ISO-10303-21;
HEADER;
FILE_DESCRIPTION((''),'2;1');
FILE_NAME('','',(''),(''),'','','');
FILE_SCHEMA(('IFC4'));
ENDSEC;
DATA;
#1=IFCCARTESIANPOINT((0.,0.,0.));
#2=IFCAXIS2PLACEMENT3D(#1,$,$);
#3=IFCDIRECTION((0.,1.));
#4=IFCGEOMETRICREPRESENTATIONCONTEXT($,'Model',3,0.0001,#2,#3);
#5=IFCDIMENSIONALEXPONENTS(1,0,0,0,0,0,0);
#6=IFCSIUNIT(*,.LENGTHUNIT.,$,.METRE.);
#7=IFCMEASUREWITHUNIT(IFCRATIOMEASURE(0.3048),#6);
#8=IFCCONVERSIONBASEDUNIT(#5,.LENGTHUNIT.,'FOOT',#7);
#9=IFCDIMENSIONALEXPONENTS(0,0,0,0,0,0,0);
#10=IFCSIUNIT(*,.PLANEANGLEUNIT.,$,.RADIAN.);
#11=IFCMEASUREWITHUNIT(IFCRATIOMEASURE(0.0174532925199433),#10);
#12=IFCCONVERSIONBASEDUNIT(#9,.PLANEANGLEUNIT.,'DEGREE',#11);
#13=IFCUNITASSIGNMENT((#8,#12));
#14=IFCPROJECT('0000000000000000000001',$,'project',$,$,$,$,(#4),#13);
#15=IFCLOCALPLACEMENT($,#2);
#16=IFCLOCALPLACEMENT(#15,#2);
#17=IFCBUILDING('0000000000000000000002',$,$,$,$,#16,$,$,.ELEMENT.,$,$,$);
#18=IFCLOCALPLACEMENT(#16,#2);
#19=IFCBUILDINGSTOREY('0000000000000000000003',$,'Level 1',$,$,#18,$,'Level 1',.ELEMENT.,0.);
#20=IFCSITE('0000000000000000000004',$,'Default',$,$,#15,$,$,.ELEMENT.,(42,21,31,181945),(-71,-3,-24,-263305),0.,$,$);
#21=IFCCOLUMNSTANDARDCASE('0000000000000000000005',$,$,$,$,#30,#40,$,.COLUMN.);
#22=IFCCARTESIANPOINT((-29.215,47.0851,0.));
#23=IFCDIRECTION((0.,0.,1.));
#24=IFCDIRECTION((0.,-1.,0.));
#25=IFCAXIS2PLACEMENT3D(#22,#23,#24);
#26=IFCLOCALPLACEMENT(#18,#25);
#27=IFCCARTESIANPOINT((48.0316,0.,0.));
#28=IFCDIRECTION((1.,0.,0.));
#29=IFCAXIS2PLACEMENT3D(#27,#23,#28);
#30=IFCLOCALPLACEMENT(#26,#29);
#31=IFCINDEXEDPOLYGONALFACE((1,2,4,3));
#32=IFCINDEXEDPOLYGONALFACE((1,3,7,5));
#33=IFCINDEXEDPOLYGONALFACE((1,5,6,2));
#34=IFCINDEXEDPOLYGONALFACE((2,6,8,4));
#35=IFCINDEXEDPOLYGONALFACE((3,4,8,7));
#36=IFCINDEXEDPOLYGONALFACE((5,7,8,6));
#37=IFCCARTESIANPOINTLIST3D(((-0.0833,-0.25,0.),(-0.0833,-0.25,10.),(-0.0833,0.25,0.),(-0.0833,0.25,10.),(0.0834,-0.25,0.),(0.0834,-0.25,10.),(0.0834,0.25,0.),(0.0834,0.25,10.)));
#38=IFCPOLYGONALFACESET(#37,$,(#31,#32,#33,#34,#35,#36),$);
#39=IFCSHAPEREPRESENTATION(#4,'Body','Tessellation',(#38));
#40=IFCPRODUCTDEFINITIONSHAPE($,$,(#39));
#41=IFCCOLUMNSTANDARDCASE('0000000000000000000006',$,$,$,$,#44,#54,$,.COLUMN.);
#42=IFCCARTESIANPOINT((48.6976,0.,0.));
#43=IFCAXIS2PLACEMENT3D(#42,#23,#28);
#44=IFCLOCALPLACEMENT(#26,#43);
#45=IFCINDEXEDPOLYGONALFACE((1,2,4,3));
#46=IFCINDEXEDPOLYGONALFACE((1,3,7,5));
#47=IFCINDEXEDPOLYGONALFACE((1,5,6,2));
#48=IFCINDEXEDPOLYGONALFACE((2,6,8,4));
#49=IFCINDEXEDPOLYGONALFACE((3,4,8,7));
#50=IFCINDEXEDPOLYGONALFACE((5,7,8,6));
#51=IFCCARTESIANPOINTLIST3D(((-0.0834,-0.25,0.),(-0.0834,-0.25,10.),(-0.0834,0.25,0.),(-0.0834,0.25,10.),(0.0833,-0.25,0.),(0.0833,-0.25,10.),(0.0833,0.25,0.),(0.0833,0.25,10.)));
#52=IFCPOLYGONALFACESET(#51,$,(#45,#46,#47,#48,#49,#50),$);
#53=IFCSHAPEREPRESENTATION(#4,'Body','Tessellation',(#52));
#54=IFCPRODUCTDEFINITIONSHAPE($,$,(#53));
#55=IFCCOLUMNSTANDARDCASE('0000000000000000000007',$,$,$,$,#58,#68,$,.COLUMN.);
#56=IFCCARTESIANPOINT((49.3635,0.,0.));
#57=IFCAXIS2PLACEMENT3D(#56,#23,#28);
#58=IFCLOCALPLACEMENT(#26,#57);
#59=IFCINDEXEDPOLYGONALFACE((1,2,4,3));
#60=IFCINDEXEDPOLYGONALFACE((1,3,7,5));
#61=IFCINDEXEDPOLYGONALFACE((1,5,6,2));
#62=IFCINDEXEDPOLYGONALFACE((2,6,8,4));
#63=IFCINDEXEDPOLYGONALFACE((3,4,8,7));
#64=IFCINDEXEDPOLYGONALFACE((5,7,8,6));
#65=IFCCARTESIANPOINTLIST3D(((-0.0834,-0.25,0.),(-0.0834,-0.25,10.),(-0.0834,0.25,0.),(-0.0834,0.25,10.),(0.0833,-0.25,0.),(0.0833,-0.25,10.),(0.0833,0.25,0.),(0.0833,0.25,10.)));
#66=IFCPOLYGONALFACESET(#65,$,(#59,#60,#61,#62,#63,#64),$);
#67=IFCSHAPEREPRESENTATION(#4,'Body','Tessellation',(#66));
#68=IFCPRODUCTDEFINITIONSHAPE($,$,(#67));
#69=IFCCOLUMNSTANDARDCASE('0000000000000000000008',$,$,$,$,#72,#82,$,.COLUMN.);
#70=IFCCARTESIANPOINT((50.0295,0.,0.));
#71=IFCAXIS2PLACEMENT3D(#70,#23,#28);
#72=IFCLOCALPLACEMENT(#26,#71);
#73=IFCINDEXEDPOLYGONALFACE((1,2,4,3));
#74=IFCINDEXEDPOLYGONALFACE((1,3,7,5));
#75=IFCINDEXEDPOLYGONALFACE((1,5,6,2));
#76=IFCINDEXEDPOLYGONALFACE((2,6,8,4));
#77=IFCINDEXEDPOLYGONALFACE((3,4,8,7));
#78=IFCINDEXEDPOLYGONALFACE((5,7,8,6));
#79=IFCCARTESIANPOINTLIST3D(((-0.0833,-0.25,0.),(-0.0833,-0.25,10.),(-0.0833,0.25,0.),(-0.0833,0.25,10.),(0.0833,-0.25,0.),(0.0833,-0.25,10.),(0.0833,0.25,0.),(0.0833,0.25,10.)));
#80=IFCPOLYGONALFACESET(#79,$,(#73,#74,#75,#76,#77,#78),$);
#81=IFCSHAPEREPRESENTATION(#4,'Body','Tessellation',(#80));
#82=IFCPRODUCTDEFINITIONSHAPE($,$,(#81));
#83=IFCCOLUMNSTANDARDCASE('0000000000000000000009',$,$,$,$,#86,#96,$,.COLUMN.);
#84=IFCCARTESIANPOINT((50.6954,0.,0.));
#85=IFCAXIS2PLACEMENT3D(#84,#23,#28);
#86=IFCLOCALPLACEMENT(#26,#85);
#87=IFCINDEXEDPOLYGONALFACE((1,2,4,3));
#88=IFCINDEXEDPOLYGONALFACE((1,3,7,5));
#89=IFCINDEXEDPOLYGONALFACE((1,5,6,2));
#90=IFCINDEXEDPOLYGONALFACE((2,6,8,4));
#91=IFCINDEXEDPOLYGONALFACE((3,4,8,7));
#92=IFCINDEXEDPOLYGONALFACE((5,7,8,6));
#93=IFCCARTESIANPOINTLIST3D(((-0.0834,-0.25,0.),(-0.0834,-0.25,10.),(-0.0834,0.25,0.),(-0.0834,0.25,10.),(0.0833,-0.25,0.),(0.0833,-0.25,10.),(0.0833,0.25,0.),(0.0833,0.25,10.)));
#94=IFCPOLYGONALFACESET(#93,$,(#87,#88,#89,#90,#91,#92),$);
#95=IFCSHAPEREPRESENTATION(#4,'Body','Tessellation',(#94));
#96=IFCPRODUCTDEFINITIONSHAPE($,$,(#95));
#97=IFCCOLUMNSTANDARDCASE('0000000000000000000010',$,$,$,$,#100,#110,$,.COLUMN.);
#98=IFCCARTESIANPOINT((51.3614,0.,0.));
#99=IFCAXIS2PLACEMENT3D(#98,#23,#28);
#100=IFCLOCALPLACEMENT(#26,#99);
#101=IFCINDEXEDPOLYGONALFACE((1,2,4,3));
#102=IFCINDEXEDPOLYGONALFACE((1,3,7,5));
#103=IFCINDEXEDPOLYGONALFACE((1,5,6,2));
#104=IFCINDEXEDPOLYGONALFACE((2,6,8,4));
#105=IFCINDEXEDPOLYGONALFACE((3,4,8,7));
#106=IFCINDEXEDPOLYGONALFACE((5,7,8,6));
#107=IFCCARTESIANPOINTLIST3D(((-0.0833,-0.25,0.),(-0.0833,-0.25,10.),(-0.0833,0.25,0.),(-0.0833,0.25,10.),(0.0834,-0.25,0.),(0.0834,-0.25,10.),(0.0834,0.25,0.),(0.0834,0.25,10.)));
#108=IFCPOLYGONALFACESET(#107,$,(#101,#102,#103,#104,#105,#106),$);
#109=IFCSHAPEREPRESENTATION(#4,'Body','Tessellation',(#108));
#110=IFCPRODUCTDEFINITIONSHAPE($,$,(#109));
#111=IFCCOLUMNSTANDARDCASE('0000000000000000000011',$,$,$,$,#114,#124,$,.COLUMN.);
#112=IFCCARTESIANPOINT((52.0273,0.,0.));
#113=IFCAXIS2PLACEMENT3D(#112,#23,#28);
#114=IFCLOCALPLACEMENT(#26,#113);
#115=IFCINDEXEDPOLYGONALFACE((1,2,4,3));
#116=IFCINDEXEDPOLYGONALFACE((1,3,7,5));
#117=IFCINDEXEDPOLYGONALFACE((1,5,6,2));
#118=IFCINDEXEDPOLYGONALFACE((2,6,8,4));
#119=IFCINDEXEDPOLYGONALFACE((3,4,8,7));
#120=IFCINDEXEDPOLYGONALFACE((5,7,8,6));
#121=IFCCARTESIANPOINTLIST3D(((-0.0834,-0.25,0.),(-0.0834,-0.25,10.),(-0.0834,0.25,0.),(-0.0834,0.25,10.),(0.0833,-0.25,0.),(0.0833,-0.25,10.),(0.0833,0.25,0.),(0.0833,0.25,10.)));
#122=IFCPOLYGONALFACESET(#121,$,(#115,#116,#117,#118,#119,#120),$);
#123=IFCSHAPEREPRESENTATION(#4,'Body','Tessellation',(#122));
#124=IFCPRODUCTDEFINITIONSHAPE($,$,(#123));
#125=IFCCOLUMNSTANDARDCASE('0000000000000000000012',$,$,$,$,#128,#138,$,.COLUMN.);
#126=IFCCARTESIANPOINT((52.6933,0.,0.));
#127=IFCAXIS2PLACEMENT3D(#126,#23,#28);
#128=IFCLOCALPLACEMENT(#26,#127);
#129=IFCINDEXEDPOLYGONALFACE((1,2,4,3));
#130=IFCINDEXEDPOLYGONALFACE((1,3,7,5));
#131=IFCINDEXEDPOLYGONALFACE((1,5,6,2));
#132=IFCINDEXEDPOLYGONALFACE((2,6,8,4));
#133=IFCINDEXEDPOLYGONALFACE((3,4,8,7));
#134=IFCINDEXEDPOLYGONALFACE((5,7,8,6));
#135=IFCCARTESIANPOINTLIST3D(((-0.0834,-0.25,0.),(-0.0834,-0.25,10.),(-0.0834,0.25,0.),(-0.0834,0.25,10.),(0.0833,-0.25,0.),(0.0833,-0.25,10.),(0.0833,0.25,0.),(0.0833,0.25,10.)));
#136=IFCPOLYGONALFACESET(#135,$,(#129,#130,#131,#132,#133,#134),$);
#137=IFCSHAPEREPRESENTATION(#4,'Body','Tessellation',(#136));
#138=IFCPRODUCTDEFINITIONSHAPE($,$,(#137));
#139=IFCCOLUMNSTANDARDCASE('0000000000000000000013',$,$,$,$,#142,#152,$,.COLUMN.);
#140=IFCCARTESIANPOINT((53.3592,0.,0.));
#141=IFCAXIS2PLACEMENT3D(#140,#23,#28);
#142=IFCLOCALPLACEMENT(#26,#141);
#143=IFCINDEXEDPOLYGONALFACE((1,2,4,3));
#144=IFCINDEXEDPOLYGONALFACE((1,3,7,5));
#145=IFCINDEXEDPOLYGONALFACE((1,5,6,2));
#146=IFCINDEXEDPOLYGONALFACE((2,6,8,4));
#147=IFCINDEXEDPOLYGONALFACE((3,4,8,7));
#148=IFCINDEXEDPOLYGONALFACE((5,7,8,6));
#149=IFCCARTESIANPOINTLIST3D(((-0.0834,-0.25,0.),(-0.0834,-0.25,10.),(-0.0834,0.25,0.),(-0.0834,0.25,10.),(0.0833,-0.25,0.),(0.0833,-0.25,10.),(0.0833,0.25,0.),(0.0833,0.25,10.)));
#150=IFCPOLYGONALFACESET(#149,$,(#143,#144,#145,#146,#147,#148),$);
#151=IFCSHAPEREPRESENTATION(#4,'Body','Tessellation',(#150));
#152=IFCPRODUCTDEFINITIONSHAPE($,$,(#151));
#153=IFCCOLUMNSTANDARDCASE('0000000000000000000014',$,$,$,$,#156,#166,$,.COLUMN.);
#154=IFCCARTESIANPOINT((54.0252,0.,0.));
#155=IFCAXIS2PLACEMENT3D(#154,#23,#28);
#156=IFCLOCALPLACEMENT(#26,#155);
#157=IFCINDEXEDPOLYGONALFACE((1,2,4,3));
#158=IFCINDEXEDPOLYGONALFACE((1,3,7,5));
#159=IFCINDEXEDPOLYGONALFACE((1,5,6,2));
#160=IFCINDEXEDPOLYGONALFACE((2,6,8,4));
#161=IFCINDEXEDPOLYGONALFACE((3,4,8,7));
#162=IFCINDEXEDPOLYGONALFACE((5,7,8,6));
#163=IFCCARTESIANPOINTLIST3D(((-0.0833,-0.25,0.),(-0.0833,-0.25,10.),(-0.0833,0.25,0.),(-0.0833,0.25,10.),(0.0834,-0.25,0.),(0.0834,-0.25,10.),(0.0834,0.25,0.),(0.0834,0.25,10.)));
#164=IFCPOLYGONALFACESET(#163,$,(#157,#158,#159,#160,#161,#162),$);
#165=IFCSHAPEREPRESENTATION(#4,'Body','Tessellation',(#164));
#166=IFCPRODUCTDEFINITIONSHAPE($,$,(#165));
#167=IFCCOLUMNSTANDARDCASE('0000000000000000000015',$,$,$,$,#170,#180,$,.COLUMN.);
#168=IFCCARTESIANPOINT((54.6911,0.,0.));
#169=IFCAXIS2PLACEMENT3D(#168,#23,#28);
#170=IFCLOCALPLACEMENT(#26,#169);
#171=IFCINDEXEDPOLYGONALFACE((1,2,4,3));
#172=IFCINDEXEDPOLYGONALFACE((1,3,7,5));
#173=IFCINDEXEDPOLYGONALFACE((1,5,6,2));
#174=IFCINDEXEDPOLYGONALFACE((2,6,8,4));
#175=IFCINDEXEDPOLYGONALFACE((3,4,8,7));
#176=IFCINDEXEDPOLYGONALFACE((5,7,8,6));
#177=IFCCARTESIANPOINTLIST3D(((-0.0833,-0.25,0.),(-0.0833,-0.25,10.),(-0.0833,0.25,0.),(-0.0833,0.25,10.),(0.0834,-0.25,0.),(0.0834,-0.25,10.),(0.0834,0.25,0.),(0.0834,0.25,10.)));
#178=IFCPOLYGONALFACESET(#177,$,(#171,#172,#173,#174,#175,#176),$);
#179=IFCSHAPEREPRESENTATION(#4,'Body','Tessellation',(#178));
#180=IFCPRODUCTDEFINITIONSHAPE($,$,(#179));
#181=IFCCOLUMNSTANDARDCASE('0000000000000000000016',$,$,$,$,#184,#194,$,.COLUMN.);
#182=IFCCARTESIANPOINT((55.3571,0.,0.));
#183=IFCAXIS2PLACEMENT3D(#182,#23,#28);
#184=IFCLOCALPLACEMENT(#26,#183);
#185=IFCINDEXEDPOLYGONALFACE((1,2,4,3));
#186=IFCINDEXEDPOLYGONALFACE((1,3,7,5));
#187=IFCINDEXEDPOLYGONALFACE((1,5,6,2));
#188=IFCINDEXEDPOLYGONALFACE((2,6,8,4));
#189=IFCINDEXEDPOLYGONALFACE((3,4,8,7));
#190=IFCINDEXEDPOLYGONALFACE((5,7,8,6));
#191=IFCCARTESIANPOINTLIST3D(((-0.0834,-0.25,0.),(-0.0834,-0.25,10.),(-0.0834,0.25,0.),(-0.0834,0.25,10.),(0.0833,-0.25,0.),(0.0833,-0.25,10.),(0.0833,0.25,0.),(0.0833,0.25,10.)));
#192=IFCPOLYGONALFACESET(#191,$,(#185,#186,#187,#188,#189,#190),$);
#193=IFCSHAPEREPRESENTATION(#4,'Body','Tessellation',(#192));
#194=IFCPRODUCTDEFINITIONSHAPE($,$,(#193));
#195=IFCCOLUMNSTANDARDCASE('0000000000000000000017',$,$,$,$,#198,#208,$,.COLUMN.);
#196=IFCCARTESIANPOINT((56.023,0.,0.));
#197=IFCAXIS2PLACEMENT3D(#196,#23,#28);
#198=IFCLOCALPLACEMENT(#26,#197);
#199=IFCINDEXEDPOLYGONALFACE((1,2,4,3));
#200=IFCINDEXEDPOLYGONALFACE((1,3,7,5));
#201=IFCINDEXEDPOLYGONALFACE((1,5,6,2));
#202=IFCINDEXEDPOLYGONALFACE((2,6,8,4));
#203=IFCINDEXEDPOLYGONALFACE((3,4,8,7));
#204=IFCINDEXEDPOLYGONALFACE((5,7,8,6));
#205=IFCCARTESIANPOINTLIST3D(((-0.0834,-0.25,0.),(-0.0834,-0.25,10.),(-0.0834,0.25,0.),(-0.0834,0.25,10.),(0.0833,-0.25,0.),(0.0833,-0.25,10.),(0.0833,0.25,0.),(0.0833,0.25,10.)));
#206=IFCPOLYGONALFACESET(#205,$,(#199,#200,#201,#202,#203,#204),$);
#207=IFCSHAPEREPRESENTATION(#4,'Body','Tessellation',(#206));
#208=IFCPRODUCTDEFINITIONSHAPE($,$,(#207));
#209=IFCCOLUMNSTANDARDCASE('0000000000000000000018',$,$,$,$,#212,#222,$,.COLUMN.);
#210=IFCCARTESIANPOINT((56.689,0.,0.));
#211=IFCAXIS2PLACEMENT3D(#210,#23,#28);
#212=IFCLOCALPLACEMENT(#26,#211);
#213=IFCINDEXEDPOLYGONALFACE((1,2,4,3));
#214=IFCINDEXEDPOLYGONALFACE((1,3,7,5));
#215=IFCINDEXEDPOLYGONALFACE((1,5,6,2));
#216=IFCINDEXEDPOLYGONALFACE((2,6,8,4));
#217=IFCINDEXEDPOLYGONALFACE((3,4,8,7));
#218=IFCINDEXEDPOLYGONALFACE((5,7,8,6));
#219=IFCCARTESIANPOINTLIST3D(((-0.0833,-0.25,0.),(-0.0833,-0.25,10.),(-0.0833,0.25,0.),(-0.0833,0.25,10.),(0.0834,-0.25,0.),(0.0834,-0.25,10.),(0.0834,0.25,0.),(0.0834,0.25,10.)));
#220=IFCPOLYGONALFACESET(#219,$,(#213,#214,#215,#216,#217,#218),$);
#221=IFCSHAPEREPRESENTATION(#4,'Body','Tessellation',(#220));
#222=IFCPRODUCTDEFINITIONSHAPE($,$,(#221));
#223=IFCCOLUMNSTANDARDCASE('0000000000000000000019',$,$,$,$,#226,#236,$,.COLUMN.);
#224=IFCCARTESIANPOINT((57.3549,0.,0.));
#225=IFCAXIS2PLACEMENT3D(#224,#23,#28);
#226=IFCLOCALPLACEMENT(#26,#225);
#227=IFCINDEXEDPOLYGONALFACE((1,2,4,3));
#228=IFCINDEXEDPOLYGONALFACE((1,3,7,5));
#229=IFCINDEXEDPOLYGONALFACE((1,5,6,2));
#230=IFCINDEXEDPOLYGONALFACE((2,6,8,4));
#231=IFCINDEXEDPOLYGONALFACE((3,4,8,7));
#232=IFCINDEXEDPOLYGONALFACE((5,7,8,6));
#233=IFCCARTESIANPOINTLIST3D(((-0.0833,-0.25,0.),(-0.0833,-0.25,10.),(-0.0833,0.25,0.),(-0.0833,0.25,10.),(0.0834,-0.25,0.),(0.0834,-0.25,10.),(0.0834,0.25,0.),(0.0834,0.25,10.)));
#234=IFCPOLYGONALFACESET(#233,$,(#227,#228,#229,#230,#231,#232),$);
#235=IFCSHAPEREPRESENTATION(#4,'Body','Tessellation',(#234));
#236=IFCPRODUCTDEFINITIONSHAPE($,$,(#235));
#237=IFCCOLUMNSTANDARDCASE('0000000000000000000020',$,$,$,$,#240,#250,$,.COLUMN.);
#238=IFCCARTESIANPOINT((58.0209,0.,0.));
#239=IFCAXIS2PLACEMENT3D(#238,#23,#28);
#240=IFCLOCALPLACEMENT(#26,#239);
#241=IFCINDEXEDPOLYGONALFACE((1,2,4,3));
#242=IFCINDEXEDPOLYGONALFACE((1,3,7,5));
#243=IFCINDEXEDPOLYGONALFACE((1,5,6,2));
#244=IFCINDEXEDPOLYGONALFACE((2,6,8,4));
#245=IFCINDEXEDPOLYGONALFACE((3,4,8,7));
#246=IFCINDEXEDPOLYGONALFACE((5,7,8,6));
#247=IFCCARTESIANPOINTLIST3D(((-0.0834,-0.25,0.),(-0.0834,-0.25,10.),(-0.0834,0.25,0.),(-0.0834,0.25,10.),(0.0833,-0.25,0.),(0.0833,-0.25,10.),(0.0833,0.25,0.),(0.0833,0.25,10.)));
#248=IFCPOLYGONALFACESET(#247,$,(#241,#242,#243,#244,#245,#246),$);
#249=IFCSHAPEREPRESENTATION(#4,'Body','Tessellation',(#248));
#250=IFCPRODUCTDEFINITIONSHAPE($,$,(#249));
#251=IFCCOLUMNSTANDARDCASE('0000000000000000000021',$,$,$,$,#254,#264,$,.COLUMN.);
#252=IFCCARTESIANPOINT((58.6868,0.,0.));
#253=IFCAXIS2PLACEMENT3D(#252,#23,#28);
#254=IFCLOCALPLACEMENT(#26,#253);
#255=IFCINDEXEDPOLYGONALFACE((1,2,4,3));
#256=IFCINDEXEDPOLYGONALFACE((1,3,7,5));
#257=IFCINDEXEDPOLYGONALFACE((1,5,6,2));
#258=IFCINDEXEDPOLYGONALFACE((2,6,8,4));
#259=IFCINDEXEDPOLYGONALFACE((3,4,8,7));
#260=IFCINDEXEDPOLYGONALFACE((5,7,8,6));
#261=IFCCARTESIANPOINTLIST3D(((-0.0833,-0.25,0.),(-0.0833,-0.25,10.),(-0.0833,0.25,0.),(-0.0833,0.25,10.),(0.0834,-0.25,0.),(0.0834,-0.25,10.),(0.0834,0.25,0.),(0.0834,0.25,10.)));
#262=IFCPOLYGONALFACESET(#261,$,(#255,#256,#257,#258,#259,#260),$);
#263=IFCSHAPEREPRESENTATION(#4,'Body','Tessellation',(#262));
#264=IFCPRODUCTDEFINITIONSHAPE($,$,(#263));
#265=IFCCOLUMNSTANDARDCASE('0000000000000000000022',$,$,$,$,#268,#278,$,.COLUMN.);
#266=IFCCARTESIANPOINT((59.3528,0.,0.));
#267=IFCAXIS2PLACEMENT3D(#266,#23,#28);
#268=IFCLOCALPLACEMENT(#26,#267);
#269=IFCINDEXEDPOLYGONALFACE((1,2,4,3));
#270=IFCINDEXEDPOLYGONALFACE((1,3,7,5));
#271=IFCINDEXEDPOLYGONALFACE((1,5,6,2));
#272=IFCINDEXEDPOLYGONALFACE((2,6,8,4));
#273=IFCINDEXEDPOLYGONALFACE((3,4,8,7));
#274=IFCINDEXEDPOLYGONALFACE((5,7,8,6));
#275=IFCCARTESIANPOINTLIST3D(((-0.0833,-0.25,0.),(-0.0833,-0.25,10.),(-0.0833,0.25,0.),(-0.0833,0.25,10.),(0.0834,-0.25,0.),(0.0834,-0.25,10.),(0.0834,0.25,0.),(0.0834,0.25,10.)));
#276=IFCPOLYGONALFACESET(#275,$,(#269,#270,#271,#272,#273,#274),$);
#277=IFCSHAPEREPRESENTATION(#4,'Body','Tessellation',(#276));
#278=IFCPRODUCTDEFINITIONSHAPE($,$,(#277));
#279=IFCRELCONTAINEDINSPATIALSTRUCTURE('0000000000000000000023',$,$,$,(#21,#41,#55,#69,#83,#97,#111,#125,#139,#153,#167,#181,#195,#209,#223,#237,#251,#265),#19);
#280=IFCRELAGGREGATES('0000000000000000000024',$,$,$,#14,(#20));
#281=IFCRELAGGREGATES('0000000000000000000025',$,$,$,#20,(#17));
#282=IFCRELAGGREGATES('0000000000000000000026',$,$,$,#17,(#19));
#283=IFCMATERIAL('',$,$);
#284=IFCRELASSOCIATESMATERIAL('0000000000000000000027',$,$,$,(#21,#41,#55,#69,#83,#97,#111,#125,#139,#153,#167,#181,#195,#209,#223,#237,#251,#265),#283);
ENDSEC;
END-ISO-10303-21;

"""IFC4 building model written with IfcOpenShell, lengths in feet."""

from ifc_helpers import new_model, entity, si_unit, converted_unit, direction, frame, origin, place, context, project, spatial, rectangle, extrude, material, element, save


model = new_model("IFC4")

# Units and contexts
model_context = context("Model", 3, precision=0.0001, world=origin(), true_north=direction((0.0, 1.0)))
ifc_project = project(units=[converted_unit("LENGTHUNIT", "FOOT", entity("IfcRatioMeasure", 0.3048), si_unit("LENGTHUNIT", "METRE"), dimensions=[1, 0, 0, 0, 0, 0, 0]), converted_unit("PLANEANGLEUNIT", "DEGREE", entity("IfcRatioMeasure", 0.0174532925199433), si_unit("PLANEANGLEUNIT", "RADIAN"), dimensions=[0, 0, 0, 0, 0, 0, 0])], contexts=[model_context])

# Site, building, storey
site_placement = place(None, origin())
site = spatial("IfcSite", under=ifc_project, at=site_placement, Name="Default", CompositionType="ELEMENT", RefLatitude=(42, 21, 31, 181945), RefLongitude=(-71, -3, -24, -263305), RefElevation=0.0)
building_placement = place(site_placement, origin())
building = spatial("IfcBuilding", under=site, at=building_placement, CompositionType="ELEMENT")
storey_placement = place(building_placement, origin())
storey = spatial("IfcBuildingStorey", under=building, at=storey_placement, Name="Level 1", LongName="Level 1", CompositionType="ELEMENT", Elevation=0.0)

# Columns
ifc_material = material(Name="")
placement = place(storey_placement, frame((-29.215, 47.0851, 0.0), z_axis=(0.0, 0.0, 1.0), x_axis=(0.0, -1.0, 0.0)))
for number, where, z_axis, x_axis in (
    (1, (48.0316, 0.0, 0.0), (0.0, 0.0, 1.0), (1.0, 0.0, 0.0)),
    (2, (48.6976, 0.0, 0.0), (0.0, 0.0, 1.0), (1.0, 0.0, 0.0)),
    (3, (49.3635, 0.0, 0.0), (0.0, 0.0, 1.0), (1.0, 0.0, 0.0)),
    (4, (50.0295, 0.0, 0.0), (0.0, 0.0, 1.0), (1.0, 0.0, 0.0)),
    (5, (50.6954, 0.0, 0.0), (0.0, 0.0, 1.0), (1.0, 0.0, 0.0)),
    (6, (51.3614, 0.0, 0.0), (0.0, 0.0, 1.0), (1.0, 0.0, 0.0)),
    (7, (52.0273, 0.0, 0.0), (0.0, 0.0, 1.0), (1.0, 0.0, 0.0)),
    (8, (52.6933, 0.0, 0.0), (0.0, 0.0, 1.0), (1.0, 0.0, 0.0)),
    (9, (53.3592, 0.0, 0.0), (0.0, 0.0, 1.0), (1.0, 0.0, 0.0)),
    (10, (54.0252, 0.0, 0.0), (0.0, 0.0, 1.0), (1.0, 0.0, 0.0)),
    (11, (54.6911, 0.0, 0.0), (0.0, 0.0, 1.0), (1.0, 0.0, 0.0)),
    (12, (55.3571, 0.0, 0.0), (0.0, 0.0, 1.0), (1.0, 0.0, 0.0)),
    (13, (56.023, 0.0, 0.0), (0.0, 0.0, 1.0), (1.0, 0.0, 0.0)),
    (14, (56.689, 0.0, 0.0), (0.0, 0.0, 1.0), (1.0, 0.0, 0.0)),
    (15, (57.3549, 0.0, 0.0), (0.0, 0.0, 1.0), (1.0, 0.0, 0.0)),
    (16, (58.0209, 0.0, 0.0), (0.0, 0.0, 1.0), (1.0, 0.0, 0.0)),
    (17, (58.6868, 0.0, 0.0), (0.0, 0.0, 1.0), (1.0, 0.0, 0.0)),
    (18, (59.3528, 0.0, 0.0), (0.0, 0.0, 1.0), (1.0, 0.0, 0.0)),
):
    element("IfcColumnStandardCase", number, at=place(placement, frame(where, z_axis=z_axis, x_axis=x_axis)), inside=storey, material=ifc_material, PredefinedType="COLUMN", context=model_context, shape_type="SweptSolid", body=[
        extrude(rectangle(XDim=0.1667, YDim=0.5), origin(), (0.0, 0.0, 1.0), 10.0),
    ])

save(model, "model.ifc")
